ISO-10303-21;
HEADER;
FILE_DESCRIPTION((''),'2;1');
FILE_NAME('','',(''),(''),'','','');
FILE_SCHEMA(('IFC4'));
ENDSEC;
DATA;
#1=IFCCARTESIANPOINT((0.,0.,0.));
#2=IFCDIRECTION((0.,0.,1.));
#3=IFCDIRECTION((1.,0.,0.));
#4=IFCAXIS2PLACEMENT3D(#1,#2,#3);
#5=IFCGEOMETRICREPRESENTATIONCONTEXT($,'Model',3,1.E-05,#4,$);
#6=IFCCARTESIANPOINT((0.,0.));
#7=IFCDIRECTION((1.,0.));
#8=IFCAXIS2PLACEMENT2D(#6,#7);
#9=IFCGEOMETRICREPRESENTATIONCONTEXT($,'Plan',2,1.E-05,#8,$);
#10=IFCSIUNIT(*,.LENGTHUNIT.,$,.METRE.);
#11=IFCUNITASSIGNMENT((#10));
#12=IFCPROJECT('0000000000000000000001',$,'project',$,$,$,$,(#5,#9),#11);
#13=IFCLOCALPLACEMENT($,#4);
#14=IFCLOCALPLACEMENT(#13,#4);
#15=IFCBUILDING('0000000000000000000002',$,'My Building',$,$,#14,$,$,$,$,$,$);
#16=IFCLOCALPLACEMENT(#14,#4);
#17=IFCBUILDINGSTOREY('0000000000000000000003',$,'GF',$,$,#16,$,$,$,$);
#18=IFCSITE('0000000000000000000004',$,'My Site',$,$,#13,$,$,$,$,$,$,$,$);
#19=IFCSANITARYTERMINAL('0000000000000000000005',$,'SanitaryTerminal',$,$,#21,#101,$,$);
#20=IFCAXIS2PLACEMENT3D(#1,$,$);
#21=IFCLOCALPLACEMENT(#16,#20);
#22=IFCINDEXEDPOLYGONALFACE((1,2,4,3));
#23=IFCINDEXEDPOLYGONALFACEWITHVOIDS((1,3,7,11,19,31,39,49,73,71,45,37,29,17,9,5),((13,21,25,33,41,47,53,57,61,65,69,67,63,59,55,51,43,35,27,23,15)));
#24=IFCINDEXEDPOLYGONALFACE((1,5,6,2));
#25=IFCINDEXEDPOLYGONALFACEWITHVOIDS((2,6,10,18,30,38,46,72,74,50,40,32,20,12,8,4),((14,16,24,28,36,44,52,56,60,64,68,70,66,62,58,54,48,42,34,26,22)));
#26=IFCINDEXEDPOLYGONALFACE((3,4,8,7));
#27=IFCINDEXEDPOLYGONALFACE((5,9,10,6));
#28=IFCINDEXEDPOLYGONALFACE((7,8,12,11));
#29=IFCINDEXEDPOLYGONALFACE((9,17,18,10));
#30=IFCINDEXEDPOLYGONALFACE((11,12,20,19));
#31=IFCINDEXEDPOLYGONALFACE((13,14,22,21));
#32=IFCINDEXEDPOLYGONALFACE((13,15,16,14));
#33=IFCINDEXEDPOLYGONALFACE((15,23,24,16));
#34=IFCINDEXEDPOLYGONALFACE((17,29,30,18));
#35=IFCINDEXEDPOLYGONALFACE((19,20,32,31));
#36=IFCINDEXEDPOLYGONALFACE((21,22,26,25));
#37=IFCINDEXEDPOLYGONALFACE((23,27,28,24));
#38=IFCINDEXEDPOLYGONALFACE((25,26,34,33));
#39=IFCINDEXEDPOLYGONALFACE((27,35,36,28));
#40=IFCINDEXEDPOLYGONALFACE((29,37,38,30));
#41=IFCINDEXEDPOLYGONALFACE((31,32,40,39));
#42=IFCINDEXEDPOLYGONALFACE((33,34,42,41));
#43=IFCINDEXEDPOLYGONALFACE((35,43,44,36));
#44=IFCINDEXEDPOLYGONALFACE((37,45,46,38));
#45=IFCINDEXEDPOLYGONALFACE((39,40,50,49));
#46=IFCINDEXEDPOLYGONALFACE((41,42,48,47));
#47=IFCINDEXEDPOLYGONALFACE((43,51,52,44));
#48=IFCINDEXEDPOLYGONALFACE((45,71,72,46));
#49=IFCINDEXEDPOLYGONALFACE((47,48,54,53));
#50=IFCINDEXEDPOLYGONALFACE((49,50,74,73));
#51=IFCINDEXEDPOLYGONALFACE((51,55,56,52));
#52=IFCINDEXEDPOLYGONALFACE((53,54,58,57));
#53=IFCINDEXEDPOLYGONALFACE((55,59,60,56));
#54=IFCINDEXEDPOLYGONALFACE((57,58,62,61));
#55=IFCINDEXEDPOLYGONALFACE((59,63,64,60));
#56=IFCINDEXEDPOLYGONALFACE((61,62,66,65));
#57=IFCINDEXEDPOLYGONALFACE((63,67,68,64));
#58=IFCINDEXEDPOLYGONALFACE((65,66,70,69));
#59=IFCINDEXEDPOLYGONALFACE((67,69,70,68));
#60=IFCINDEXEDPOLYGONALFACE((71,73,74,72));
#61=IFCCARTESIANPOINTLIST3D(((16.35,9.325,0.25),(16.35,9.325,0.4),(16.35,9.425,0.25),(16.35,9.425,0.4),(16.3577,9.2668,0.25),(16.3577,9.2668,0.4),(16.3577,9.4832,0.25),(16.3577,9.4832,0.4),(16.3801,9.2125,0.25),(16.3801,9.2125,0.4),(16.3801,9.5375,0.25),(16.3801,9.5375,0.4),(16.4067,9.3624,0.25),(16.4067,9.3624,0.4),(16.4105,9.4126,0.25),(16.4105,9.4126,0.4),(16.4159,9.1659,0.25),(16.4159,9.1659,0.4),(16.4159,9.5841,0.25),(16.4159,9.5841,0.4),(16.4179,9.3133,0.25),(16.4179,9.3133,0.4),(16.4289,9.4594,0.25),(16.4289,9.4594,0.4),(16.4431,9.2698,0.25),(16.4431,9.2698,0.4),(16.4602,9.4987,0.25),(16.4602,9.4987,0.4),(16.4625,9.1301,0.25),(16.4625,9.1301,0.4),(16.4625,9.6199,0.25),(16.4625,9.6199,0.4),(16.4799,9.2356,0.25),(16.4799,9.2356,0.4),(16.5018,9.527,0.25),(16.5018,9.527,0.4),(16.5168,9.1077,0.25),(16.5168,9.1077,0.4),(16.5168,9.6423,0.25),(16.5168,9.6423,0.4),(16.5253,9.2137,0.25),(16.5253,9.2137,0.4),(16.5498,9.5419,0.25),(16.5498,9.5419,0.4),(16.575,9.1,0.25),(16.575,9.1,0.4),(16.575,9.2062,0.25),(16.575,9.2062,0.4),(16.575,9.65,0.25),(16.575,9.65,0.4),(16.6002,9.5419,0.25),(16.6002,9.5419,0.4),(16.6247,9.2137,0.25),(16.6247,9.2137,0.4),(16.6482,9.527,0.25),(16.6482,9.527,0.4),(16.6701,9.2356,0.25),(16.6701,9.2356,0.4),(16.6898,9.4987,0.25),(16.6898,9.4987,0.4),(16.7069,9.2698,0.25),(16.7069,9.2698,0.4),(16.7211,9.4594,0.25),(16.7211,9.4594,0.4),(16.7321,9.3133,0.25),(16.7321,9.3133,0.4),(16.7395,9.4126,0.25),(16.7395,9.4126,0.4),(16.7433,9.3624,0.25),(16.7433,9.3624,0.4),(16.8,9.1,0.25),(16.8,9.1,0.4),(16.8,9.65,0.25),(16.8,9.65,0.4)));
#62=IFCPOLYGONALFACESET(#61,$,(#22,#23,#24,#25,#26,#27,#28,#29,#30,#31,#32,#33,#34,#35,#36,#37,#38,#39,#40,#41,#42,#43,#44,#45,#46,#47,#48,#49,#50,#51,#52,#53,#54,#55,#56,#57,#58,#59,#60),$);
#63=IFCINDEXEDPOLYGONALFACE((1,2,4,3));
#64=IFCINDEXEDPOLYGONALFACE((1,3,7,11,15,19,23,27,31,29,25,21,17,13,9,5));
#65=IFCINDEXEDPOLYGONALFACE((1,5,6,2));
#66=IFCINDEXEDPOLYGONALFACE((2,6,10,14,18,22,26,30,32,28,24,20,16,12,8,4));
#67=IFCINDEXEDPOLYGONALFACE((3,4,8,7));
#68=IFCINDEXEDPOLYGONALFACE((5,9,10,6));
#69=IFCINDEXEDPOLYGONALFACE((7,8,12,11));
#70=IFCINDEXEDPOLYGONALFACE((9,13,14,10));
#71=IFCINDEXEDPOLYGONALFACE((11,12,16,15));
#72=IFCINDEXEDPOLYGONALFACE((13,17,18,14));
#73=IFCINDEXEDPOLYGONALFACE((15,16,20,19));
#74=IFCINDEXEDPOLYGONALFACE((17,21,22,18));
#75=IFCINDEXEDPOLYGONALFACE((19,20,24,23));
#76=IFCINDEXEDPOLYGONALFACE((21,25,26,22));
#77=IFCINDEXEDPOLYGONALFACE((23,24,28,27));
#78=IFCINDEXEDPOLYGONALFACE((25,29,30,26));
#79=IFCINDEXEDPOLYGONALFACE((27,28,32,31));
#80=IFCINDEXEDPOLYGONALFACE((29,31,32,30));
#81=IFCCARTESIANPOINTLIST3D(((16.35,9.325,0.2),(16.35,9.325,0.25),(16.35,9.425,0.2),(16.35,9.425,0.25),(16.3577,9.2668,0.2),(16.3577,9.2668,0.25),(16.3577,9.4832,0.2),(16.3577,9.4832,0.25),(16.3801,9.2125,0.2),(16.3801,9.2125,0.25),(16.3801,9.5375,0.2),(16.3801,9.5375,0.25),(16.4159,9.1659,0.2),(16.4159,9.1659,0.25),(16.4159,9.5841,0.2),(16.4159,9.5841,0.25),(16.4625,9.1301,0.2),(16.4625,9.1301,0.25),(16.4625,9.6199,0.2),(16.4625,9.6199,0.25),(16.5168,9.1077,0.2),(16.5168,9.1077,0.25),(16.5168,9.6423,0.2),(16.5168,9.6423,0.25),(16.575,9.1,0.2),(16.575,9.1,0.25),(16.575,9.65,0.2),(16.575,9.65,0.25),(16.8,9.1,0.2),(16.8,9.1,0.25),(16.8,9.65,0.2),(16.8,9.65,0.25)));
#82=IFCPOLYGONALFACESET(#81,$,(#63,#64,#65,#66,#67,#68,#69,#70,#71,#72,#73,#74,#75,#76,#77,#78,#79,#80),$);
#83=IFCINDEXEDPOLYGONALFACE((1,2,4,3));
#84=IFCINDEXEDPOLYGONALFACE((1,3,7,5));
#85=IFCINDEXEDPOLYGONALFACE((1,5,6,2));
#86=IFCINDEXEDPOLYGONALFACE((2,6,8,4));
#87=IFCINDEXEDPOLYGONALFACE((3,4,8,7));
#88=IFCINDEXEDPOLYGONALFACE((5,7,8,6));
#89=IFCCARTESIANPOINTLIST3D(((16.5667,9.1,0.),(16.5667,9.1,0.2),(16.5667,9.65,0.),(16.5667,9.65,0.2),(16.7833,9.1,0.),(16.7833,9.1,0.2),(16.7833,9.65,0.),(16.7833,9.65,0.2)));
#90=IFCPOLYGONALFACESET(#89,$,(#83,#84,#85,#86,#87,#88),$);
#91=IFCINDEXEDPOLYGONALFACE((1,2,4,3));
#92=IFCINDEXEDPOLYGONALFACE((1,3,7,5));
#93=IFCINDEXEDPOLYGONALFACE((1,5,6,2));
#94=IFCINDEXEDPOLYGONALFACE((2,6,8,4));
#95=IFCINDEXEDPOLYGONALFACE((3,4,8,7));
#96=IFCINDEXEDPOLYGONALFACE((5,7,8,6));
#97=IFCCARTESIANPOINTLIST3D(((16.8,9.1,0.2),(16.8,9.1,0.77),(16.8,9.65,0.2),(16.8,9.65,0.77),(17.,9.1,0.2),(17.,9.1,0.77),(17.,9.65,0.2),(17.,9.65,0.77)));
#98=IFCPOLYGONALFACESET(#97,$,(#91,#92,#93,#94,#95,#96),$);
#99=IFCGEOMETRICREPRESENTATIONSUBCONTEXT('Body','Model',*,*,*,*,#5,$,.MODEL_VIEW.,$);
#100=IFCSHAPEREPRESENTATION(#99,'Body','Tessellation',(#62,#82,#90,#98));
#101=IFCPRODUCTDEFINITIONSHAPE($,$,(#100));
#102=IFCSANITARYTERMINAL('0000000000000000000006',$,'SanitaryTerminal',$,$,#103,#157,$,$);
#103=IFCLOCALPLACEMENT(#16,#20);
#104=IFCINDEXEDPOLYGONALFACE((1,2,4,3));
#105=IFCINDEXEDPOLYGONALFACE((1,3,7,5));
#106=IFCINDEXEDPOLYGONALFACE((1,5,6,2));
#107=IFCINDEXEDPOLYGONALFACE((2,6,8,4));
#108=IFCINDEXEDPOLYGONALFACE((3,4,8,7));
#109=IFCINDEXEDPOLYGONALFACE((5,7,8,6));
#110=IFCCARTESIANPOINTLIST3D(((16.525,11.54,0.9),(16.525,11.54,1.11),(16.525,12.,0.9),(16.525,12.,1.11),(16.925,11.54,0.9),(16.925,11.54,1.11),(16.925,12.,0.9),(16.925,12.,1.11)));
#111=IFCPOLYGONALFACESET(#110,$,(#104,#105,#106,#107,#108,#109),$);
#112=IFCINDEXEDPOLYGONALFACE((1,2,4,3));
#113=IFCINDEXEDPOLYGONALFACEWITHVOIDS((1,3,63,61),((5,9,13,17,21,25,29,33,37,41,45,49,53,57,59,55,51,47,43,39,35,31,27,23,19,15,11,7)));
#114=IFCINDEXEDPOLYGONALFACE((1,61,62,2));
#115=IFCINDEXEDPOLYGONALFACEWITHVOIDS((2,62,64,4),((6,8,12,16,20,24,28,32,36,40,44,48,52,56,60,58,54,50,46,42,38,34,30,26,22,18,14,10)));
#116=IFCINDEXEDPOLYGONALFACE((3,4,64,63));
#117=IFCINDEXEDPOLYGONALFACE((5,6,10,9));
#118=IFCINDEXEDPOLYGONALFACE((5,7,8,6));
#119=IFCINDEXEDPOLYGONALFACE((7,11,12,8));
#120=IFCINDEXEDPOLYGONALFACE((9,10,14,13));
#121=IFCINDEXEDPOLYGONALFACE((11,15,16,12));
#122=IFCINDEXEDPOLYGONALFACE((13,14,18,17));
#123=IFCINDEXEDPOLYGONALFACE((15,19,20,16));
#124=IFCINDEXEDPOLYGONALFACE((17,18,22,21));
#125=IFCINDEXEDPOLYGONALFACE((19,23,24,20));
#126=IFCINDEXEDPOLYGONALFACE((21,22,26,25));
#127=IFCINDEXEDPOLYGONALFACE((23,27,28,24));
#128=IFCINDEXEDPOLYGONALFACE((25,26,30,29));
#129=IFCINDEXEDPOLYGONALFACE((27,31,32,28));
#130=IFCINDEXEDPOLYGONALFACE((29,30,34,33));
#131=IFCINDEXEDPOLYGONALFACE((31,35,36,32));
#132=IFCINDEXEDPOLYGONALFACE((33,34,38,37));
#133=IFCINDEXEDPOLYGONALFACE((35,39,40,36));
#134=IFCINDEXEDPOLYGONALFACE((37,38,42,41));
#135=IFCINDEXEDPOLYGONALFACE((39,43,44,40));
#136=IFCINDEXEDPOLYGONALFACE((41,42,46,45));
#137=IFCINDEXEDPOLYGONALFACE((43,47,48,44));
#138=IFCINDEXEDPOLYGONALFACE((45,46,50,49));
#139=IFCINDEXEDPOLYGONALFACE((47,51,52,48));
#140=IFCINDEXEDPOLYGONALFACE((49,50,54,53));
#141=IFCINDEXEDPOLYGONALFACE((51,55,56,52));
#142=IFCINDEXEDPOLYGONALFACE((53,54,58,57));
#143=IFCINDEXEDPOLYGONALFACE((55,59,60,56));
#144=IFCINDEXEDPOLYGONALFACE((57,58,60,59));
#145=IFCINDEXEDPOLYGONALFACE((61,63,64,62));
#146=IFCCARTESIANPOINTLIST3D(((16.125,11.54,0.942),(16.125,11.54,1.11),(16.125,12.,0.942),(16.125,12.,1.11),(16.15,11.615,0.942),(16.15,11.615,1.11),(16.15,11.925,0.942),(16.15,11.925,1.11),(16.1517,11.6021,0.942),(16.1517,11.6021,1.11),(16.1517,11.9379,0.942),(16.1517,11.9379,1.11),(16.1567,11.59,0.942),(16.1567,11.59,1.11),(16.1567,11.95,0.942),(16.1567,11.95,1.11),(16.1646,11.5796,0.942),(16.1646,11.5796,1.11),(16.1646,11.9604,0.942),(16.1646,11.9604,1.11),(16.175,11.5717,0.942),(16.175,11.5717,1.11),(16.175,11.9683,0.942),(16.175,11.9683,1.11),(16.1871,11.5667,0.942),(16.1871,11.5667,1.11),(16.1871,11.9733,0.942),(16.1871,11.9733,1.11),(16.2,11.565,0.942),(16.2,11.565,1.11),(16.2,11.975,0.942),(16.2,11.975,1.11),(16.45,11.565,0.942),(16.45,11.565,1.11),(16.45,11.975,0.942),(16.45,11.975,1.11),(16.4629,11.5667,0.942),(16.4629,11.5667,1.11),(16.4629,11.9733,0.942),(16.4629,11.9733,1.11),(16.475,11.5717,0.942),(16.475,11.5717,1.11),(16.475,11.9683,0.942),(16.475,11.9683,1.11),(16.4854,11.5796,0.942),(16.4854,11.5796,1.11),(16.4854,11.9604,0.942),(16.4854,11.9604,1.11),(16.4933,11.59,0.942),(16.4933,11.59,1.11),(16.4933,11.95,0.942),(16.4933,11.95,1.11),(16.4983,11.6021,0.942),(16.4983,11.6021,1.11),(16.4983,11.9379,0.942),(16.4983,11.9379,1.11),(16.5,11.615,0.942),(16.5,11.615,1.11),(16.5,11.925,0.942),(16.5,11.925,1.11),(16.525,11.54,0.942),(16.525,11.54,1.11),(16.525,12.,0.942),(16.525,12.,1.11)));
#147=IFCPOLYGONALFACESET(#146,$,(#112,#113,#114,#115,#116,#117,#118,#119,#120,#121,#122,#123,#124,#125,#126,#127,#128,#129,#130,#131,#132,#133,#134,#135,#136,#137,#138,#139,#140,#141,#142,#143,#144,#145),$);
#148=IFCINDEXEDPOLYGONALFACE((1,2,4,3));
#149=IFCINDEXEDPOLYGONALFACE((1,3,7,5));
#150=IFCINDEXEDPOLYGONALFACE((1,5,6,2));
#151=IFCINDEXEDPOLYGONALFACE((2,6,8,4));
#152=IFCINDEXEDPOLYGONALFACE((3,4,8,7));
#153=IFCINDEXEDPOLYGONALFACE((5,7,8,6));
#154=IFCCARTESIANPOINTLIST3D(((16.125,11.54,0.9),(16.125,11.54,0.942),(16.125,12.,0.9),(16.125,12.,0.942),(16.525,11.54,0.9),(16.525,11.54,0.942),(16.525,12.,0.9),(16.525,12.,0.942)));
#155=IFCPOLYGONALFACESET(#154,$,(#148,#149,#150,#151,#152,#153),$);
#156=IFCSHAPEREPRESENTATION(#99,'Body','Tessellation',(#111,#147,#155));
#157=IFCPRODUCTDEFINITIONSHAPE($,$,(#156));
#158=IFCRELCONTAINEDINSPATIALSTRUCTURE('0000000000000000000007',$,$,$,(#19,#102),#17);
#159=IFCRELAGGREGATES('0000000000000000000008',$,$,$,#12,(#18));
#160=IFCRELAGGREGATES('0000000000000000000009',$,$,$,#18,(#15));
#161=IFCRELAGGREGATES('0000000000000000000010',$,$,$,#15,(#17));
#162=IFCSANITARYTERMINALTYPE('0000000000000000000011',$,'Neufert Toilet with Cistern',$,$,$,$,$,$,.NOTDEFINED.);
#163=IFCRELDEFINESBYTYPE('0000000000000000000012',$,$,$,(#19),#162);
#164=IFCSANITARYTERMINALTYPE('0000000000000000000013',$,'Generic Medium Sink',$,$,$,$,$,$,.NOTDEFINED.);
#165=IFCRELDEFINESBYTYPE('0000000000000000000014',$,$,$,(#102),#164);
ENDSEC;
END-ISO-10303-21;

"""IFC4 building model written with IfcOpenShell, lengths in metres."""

from ifc_helpers import new_model, entity, si_unit, frame, frame_2d, origin_with_axes, origin_2d_with_axis, place, context, subcontext, project, spatial, line, arc, indexed_curve, circle_curve, outline, extrude, shape, source, transform, mapped, type_object, type_shapes, element, save


model = new_model("IFC4")

# Units and contexts
model_context = context("Model", 3, precision=1e-05, world=origin_with_axes())
plan_context = context("Plan", 2, precision=1e-05, world=origin_2d_with_axis())
body_context_1 = subcontext(model_context, "Body", "Model", "MODEL_VIEW")
body_context_2 = subcontext(plan_context, "Body", "Plan", "PLAN_VIEW")
ifc_project = project(units=[si_unit("LENGTHUNIT", "METRE")], contexts=[model_context, plan_context])

# Site, building, storey
site_placement = place(None, origin_with_axes())
site = spatial("IfcSite", under=ifc_project, at=site_placement, Name="My Site")
building_placement = place(site_placement, origin_with_axes())
building = spatial("IfcBuilding", under=site, at=building_placement, Name="My Building")
storey_placement = place(building_placement, origin_with_axes())
storey = spatial("IfcBuildingStorey", under=building, at=storey_placement, Name="GF")

# Sanitary terminals
sanitary_terminal_type_1 = type_object("IfcSanitaryTerminalType", Name="Neufert Toilet with Cistern", PredefinedType="NOTDEFINED")
shared_shape_1 = source(origin_with_axes(), body_context_1, "Body", "SweptSolid", [
    extrude(outline(indexed_curve([(-0.275, -0.2), (0.275, -0.2), (0.275, -0.425), (0.2091, -0.5841), (0.05, -0.65), (-0.05, -0.65), (-0.2091, -0.5841), (-0.275, -0.425)], segments=[line(1, 2), line(2, 3), arc(3, 4, 5), line(5, 6), arc(6, 7, 8), line(8, 1)]), holes=[circle_curve(frame_2d((0.0, -0.425)), 0.1688)]), frame((0.0, 0.0, 0.25), z_axis=(0.0, 0.0, 1.0), x_axis=(1.0, 0.0, 0.0)), (0.0, 0.0, 1.0), 0.15),
    extrude(outline(indexed_curve([(-0.275, -0.2), (0.275, -0.2), (0.275, -0.425), (0.2091, -0.5841), (0.05, -0.65), (-0.05, -0.65), (-0.2091, -0.5841), (-0.275, -0.425)], segments=[line(1, 2), line(2, 3), arc(3, 4, 5), line(5, 6), arc(6, 7, 8), line(8, 1)])), frame((0.0, 0.0, 0.2), z_axis=(0.0, 0.0, 1.0), x_axis=(1.0, 0.0, 0.0)), (0.0, 0.0, 1.0), 0.05),
    extrude(outline(indexed_curve([(-0.275, -0.2167), (0.275, -0.2167), (0.275, -0.4333), (-0.275, -0.4333)], segments=[line(1, 2, 3, 4, 1)])), origin_with_axes(), (0.0, 0.0, 1.0), 0.2),
    extrude(outline(indexed_curve([(-0.275, 0.0), (0.275, 0.0), (0.275, -0.2), (-0.275, -0.2)], segments=[line(1, 2, 3, 4, 1)])), frame((0.0, 0.0, 0.2), z_axis=(0.0, 0.0, 1.0), x_axis=(1.0, 0.0, 0.0)), (0.0, 0.0, 1.0), 0.57),
])
shared_shape_2 = source(origin_with_axes(), body_context_2, "Body", "Curve2D", [
    entity("IfcIndexedPolyCurve", entity("IfcCartesianPointList2D", [[-0.275, 0.0], [0.275, 0.0], [0.275, -0.2], [-0.275, -0.2]]), [entity("IfcLineIndex", [1, 2, 3, 4, 1])]),
    entity("IfcIndexedPolyCurve", entity("IfcCartesianPointList2D", [[0.165, -0.2], [0.1925, -0.335]])),
    entity("IfcTrimmedCurve", entity("IfcEllipse", entity("IfcAxis2Placement2D", entity("IfcCartesianPoint", [0.0, -0.335]), entity("IfcDirection", [1.0, 0.0])), 0.1925, 0.315), [entity("IfcCartesianPoint", [-0.1925, -0.335])], [entity("IfcCartesianPoint", [0.1925, -0.335])], True, "CARTESIAN"),
    entity("IfcIndexedPolyCurve", entity("IfcCartesianPointList2D", [[-0.165, -0.2], [-0.1925, -0.335]])),
    entity("IfcEllipse", entity("IfcAxis2Placement2D", entity("IfcCartesianPoint", [0.0, -0.452]), entity("IfcDirection", [1.0, 0.0])), 0.1313, 0.1575),
    entity("IfcIndexedPolyCurve", entity("IfcCartesianPointList2D", [[-0.0344, -0.452], [-0.0344, -0.4295], [0.0344, -0.4295], [0.0344, -0.452]])),
    entity("IfcTrimmedCurve", entity("IfcEllipse", entity("IfcAxis2Placement2D", entity("IfcCartesianPoint", [0.0, -0.452]), entity("IfcDirection", [1.0, 0.0])), 0.0344, 0.0225), [entity("IfcCartesianPoint", [-0.0344, -0.452])], [entity("IfcCartesianPoint", [0.0344, -0.452])], True, "CARTESIAN"),
])
type_shapes(sanitary_terminal_type_1, [shared_shape_1, shared_shape_2])
for number, where, z_axis, x_axis, name in (
    (1, (17.0, 9.375, 0.0), (0.0, 0.0, 1.0), (0.0, -1.0, 0.0), "SanitaryTerminal"),
):
    element("IfcSanitaryTerminal", number, at=place(storey_placement, frame(where, z_axis=z_axis, x_axis=x_axis)), inside=storey, type_object=sanitary_terminal_type_1, Name=name, shapes=[
        shape(body_context_1, "Body", "MappedRepresentation", [mapped(shared_shape_1, transform((0.0, 0.0, 0.0), x_axis=(1.0, 0.0, 0.0), y_axis=(0.0, 1.0, 0.0), z_axis=(0.0, 0.0, 1.0), scale=1.0))]),
        shape(body_context_2, "Body", "MappedRepresentation", [mapped(shared_shape_2, transform((0.0, 0.0, 0.0), x_axis=(1.0, 0.0, 0.0), y_axis=(0.0, 1.0, 0.0), z_axis=(0.0, 0.0, 1.0), scale=1.0))]),
    ])
sanitary_terminal_type_2 = type_object("IfcSanitaryTerminalType", Name="Generic Medium Sink", PredefinedType="NOTDEFINED")
shared_indexed_poly_curve = entity("IfcIndexedPolyCurve", entity("IfcCartesianPointList2D", [[0.4, 0.0], [0.8, 0.0], [0.8, 0.46], [0.4, 0.46]]), [entity("IfcLineIndex", [1, 2, 3, 4, 1])])
shared_shape_3 = source(origin_with_axes(), body_context_1, "Body", "SweptSolid", [
    extrude(outline(indexed_curve([(0.0, 0.0), (0.4, 0.0), (0.4, 0.46), (0.0, 0.46)], segments=[line(1, 2, 3, 4, 1)])), frame((-0.4, -0.46, 0.0), z_axis=(0.0, 0.0, 1.0), x_axis=(1.0, 0.0, 0.0)), (0.0, 0.0, 1.0), 0.21),
    entity("IfcExtrudedAreaSolid", entity("IfcArbitraryProfileDefWithVoids", "AREA", None, shared_indexed_poly_curve, [entity("IfcIndexedPolyCurve", entity("IfcCartesianPointList2D", [[0.425, 0.075], [0.4396, 0.0396], [0.475, 0.025], [0.725, 0.025], [0.7604, 0.0396], [0.775, 0.075], [0.775, 0.385], [0.7604, 0.4204], [0.725, 0.435], [0.475, 0.435], [0.4396, 0.4204], [0.425, 0.385]]), [entity("IfcLineIndex", [12, 1]), entity("IfcArcIndex", [1, 2, 3]), entity("IfcLineIndex", [3, 4]), entity("IfcArcIndex", [4, 5, 6]), entity("IfcLineIndex", [6, 7]), entity("IfcArcIndex", [7, 8, 9]), entity("IfcLineIndex", [9, 10]), entity("IfcArcIndex", [10, 11, 12]), entity("IfcLineIndex", [12, 1])])]), entity("IfcAxis2Placement3D", entity("IfcCartesianPoint", [-0.4, -0.46, 0.042]), entity("IfcDirection", [0.0, 0.0, 1.0]), entity("IfcDirection", [1.0, 0.0, 0.0])), entity("IfcDirection", [0.0, 0.0, 1.0]), 0.168),
    entity("IfcExtrudedAreaSolid", entity("IfcArbitraryClosedProfileDef", "AREA", None, shared_indexed_poly_curve), entity("IfcAxis2Placement3D", entity("IfcCartesianPoint", [-0.4, -0.46, 0.0]), entity("IfcDirection", [0.0, 0.0, 1.0]), entity("IfcDirection", [1.0, 0.0, 0.0])), entity("IfcDirection", [0.0, 0.0, 1.0]), 0.042),
])
shared_shape_4 = source(origin_with_axes(), body_context_2, "Body", "Curve2D", [
    entity("IfcIndexedPolyCurve", entity("IfcCartesianPointList2D", [[-0.4, -0.46], [0.4, -0.46], [0.4, 0.0], [-0.4, 0.0]]), [entity("IfcLineIndex", [1, 2, 3, 4, 1])]),
    entity("IfcIndexedPolyCurve", entity("IfcCartesianPointList2D", [[0.025, -0.385], [0.0396, -0.4204], [0.075, -0.435], [0.325, -0.435], [0.3604, -0.4204], [0.375, -0.385], [0.375, -0.075], [0.3604, -0.0396], [0.325, -0.025], [0.075, -0.025], [0.0396, -0.0396], [0.025, -0.075]]), [entity("IfcLineIndex", [12, 1]), entity("IfcArcIndex", [1, 2, 3]), entity("IfcLineIndex", [3, 4]), entity("IfcArcIndex", [4, 5, 6]), entity("IfcLineIndex", [6, 7]), entity("IfcArcIndex", [7, 8, 9]), entity("IfcLineIndex", [9, 10]), entity("IfcArcIndex", [10, 11, 12]), entity("IfcLineIndex", [12, 1])]),
    entity("IfcCircle", entity("IfcAxis2Placement2D", entity("IfcCartesianPoint", [0.2, -0.125])), 0.025),
    entity("IfcIndexedPolyCurve", entity("IfcCartesianPointList2D", [[0.2, -0.0125], [0.2, -0.1325]])),
])
type_shapes(sanitary_terminal_type_2, [shared_shape_3, shared_shape_4])
for number, where, z_axis, x_axis, name in (
    (2, (16.525, 11.54, 0.9), (0.0, 0.0, 1.0), (-1.0, 0.0, 0.0), "SanitaryTerminal"),
):
    element("IfcSanitaryTerminal", number, at=place(storey_placement, frame(where, z_axis=z_axis, x_axis=x_axis)), inside=storey, type_object=sanitary_terminal_type_2, Name=name, shapes=[
        shape(body_context_1, "Body", "MappedRepresentation", [mapped(shared_shape_3, transform((0.0, 0.0, 0.0), x_axis=(1.0, 0.0, 0.0), y_axis=(0.0, 1.0, 0.0), z_axis=(0.0, 0.0, 1.0), scale=1.0))]),
        shape(body_context_2, "Body", "MappedRepresentation", [mapped(shared_shape_4, transform((0.0, 0.0, 0.0), x_axis=(1.0, 0.0, 0.0), y_axis=(0.0, 1.0, 0.0), z_axis=(0.0, 0.0, 1.0), scale=1.0))]),
    ])

save(model, "model.ifc")
